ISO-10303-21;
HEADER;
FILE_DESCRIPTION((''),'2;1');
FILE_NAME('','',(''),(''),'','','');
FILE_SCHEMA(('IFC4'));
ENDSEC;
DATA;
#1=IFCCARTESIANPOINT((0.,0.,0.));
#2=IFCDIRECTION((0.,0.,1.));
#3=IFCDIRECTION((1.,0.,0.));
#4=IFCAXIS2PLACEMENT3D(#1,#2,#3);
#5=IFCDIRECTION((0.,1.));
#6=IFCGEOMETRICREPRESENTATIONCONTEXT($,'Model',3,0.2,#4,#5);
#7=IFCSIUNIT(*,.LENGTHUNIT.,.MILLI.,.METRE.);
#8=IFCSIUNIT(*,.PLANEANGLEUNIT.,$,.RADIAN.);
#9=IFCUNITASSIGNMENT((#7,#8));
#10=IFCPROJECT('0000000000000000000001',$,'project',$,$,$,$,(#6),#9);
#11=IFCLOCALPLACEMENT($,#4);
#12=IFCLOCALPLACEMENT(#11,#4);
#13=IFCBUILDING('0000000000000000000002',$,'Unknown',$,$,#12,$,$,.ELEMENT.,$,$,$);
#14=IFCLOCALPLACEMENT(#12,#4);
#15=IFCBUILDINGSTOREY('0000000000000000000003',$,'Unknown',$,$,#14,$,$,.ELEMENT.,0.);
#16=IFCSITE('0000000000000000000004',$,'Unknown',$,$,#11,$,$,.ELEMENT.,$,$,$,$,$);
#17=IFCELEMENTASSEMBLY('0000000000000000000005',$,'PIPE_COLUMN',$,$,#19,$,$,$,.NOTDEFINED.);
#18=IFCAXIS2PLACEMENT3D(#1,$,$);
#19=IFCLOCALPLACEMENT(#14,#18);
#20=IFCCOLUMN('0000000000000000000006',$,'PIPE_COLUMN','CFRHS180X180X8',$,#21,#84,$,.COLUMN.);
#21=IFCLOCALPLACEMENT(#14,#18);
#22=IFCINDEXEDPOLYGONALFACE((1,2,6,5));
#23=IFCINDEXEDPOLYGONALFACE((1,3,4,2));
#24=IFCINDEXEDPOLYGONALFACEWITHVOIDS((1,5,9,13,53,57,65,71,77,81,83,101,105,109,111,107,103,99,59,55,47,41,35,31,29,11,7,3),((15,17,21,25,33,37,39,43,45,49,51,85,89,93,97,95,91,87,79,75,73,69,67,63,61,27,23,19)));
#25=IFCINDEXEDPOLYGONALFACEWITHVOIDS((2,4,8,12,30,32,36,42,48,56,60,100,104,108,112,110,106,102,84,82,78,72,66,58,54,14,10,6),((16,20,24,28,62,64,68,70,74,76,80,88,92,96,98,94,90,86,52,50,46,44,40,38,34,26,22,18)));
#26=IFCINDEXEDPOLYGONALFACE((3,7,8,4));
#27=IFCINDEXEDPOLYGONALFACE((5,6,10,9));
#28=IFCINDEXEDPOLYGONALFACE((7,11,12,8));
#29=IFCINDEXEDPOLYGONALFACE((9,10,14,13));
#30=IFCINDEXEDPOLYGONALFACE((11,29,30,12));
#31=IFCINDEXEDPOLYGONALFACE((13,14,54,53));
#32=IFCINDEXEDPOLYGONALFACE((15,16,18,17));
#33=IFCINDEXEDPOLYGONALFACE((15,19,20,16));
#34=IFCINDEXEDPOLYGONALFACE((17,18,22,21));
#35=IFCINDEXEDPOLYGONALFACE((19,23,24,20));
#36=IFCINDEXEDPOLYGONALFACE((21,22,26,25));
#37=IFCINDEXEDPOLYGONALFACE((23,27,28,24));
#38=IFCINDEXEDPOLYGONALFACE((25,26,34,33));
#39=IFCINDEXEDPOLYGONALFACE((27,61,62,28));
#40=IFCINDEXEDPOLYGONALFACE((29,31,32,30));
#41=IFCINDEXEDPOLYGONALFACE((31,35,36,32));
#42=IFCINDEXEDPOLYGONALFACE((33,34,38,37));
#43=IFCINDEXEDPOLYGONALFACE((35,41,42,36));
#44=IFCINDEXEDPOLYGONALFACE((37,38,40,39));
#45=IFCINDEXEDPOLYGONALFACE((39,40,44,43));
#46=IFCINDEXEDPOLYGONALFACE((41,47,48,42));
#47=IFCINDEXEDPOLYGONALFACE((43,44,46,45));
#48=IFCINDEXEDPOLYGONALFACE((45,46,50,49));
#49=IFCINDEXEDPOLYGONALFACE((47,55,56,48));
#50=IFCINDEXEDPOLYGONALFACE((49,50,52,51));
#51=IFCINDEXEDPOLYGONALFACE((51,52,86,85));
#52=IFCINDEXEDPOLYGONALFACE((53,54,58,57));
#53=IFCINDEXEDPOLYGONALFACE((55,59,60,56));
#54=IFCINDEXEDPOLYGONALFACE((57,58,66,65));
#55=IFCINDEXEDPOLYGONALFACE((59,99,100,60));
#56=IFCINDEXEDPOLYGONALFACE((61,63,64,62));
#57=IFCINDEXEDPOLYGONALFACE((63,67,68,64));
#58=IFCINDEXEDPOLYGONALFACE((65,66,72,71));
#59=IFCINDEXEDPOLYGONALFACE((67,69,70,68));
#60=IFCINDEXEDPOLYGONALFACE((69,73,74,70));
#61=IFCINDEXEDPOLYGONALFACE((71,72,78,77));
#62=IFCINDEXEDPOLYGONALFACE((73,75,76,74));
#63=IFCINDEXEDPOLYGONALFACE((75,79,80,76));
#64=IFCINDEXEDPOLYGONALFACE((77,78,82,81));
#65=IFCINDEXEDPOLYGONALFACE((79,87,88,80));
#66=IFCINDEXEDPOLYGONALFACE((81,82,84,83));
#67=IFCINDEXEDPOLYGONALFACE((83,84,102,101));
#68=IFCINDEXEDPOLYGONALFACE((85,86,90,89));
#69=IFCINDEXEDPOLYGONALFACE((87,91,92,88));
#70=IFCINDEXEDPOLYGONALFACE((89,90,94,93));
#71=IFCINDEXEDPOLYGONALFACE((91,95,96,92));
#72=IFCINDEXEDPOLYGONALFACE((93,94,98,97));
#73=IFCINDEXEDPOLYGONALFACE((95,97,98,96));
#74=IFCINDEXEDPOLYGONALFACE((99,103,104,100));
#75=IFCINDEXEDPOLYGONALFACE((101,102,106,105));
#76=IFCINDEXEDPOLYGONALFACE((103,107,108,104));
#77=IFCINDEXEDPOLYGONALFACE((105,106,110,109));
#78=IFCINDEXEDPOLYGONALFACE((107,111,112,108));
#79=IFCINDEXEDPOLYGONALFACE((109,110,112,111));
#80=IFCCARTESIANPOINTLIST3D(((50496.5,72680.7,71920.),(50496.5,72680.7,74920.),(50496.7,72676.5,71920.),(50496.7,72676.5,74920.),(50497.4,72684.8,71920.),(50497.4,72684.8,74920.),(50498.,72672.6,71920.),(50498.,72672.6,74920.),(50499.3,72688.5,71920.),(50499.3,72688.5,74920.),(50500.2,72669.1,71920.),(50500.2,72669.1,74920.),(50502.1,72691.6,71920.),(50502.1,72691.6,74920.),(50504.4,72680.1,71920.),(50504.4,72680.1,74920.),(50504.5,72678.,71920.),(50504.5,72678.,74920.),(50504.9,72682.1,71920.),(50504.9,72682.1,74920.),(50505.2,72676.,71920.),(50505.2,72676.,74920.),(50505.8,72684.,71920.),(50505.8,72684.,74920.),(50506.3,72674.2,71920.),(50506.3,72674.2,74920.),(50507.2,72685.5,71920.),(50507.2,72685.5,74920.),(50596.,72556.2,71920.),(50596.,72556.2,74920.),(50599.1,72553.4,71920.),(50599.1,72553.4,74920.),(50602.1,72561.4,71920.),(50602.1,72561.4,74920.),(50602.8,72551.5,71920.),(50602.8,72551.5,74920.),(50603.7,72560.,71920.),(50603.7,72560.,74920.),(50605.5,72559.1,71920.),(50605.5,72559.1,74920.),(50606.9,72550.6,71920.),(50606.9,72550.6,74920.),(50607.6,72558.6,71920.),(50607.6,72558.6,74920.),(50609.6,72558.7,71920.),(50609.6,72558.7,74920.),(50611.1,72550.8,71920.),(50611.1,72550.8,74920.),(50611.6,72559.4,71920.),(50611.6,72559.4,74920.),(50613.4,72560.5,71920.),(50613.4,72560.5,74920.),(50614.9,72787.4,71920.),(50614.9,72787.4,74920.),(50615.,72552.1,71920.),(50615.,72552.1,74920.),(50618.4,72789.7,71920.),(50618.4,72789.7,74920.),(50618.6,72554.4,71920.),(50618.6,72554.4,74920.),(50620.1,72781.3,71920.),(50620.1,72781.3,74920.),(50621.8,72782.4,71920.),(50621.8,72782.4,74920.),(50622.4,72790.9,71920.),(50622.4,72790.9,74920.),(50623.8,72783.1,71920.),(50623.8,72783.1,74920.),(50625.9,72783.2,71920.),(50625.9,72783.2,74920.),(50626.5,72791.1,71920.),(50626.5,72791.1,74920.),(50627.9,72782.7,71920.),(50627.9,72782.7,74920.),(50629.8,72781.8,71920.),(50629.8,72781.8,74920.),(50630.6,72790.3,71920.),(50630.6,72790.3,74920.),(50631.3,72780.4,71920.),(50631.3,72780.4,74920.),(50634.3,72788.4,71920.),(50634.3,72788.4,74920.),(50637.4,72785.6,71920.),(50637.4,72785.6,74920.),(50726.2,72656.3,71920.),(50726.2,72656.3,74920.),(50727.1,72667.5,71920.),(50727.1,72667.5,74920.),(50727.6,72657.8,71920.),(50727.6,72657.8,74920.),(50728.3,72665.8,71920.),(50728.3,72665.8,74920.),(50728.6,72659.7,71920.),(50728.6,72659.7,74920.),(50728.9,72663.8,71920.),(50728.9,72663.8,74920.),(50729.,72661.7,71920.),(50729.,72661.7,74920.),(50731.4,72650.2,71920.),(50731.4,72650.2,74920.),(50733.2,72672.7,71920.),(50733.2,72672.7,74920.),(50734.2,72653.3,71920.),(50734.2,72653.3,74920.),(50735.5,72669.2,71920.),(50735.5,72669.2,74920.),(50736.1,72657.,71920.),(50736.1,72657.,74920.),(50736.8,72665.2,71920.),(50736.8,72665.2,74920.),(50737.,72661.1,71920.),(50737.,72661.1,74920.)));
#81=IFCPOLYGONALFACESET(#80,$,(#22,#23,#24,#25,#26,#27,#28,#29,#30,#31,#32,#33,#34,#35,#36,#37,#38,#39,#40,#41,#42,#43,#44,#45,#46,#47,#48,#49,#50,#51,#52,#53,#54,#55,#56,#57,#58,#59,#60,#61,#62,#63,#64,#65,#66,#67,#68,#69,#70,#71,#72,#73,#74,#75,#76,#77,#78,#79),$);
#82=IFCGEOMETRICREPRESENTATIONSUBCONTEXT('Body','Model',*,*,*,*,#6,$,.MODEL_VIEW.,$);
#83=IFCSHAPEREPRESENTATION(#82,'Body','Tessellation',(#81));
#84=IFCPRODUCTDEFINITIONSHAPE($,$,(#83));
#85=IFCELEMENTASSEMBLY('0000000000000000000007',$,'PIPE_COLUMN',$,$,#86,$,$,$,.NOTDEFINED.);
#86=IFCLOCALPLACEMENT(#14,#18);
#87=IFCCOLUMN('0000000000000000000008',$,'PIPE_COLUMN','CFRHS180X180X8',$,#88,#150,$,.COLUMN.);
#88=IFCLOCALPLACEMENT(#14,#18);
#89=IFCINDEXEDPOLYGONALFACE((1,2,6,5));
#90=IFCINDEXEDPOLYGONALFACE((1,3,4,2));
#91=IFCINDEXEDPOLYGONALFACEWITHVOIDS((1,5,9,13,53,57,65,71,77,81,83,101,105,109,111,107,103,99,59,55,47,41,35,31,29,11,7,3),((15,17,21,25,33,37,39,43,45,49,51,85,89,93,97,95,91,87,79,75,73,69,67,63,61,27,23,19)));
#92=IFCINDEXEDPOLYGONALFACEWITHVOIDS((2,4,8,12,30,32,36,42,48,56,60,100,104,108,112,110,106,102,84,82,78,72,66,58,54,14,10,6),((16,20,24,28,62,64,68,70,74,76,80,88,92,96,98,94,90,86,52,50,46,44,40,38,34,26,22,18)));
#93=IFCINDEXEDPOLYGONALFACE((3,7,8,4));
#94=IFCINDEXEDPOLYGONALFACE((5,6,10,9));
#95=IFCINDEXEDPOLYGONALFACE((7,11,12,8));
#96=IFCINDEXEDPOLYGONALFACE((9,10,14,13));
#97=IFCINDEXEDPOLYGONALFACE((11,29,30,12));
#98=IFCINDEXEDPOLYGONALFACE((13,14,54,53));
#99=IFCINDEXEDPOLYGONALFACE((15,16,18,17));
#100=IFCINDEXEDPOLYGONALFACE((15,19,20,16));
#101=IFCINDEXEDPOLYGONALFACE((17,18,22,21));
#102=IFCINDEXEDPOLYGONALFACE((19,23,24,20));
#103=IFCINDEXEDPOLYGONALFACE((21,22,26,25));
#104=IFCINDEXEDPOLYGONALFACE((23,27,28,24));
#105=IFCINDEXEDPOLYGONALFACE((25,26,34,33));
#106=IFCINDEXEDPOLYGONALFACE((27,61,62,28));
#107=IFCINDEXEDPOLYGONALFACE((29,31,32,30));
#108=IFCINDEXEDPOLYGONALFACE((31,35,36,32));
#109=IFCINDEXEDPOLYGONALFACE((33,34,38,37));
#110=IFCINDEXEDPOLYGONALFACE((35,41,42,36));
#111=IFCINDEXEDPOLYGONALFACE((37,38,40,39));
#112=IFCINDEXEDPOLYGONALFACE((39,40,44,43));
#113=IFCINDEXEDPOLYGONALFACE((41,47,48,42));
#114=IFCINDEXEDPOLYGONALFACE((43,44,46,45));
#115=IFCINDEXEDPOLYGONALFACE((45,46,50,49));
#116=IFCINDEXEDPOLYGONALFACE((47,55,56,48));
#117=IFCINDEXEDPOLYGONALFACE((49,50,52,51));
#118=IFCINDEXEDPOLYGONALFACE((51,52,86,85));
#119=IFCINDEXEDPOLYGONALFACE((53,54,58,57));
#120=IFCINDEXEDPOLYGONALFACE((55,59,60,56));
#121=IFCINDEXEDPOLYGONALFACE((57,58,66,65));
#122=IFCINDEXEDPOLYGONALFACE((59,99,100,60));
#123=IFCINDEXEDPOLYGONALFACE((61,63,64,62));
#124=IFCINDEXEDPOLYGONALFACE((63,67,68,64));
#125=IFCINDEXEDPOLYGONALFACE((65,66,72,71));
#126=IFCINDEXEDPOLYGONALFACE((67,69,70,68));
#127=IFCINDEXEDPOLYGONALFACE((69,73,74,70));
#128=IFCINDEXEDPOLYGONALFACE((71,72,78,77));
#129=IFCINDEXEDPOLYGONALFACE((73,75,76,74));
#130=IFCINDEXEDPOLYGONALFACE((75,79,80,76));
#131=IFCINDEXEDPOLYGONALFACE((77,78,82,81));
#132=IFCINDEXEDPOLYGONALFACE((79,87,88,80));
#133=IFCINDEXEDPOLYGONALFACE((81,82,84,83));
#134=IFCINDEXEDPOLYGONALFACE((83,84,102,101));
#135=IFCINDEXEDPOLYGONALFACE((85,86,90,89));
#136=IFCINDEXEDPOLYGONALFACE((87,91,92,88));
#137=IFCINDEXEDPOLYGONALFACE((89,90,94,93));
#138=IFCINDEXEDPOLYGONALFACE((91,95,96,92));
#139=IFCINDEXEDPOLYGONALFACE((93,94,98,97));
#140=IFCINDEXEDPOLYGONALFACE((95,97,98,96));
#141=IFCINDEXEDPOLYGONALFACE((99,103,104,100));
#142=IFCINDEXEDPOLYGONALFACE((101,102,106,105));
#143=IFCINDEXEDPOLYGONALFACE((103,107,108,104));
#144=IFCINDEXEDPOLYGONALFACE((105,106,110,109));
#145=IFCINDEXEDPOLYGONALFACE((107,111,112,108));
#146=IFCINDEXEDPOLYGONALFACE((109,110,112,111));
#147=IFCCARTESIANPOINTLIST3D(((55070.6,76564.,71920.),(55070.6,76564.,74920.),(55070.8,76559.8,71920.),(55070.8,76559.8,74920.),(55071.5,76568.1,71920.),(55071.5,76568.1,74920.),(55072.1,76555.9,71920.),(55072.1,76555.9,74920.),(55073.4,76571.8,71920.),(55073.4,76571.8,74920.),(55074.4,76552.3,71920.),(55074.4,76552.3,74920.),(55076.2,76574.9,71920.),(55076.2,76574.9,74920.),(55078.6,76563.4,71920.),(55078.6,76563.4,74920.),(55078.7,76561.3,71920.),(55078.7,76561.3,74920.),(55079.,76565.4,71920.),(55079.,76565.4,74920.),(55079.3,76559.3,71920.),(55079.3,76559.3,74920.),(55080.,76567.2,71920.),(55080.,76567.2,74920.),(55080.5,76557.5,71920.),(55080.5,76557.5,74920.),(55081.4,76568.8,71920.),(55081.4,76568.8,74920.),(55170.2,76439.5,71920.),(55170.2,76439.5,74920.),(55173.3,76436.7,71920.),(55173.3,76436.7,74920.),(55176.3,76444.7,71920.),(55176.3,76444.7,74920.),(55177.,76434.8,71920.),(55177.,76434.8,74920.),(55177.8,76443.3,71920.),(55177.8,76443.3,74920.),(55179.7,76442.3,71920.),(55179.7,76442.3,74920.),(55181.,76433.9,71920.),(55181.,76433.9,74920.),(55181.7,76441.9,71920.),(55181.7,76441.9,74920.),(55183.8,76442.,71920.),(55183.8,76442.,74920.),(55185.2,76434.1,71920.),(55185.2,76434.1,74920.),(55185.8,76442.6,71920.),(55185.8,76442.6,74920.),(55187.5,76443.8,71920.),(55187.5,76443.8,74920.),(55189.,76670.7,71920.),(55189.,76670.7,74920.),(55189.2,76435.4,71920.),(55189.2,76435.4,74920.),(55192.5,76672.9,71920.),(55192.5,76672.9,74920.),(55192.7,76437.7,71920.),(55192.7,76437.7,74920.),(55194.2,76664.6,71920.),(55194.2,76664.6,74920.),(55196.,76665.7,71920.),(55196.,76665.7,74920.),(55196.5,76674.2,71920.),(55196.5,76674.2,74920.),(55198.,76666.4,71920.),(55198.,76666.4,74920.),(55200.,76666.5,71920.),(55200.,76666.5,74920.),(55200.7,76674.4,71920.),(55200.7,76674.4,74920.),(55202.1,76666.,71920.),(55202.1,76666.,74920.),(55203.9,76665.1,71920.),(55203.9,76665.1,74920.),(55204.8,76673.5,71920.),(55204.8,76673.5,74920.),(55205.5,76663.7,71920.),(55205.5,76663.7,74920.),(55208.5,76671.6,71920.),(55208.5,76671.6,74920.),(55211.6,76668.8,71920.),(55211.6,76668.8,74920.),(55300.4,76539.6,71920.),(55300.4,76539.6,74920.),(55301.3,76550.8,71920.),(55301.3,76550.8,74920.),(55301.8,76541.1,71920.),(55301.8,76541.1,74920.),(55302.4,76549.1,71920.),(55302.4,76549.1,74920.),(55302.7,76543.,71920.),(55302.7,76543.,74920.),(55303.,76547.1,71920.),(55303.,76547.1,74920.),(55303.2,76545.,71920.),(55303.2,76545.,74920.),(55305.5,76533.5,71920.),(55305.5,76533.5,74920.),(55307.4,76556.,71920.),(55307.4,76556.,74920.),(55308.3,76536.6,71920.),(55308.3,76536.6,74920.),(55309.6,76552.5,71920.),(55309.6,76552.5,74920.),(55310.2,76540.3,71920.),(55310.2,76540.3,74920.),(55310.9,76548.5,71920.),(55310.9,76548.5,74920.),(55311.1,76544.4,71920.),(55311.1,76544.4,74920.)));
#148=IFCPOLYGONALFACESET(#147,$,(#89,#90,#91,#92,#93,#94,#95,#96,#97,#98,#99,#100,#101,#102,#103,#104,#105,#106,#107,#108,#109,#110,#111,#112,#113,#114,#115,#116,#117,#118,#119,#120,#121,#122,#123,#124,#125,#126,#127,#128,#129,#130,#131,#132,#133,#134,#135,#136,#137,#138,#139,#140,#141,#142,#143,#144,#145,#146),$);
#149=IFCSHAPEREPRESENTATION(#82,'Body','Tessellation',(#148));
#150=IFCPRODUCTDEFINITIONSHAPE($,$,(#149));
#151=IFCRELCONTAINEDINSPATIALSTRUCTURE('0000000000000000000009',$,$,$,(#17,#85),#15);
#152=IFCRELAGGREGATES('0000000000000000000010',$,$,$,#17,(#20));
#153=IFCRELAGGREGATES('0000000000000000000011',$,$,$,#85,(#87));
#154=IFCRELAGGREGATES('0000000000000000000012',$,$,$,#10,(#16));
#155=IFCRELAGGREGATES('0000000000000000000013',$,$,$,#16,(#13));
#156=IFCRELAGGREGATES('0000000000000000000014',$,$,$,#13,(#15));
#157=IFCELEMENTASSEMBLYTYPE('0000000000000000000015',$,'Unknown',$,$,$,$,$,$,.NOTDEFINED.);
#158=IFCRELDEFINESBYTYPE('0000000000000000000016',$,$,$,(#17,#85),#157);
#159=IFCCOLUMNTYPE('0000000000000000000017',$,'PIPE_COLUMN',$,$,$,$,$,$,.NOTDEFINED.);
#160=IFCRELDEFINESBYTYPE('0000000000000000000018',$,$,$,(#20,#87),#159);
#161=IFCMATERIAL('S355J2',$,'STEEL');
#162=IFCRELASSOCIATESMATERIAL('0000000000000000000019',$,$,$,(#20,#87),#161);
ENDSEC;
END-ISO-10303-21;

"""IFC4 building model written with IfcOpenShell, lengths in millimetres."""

from ifc_helpers import new_model, si_unit, direction, frame, origin_with_axes, origin_2d_with_axis, place, context, subcontext, project, spatial, hollow_rectangle, extrude, material, material_profile, profile_set, profile_usage, type_object, element, aggregate, save


model = new_model("IFC4")

# Units and contexts
model_context = context("Model", 3, precision=0.2, world=origin_with_axes(), true_north=direction((0.0, 1.0)))
body_context = subcontext(model_context, "Body", "Model", "MODEL_VIEW")
ifc_project = project(units=[si_unit("LENGTHUNIT", "METRE", prefix="MILLI"), si_unit("PLANEANGLEUNIT", "RADIAN")], contexts=[model_context])

# Site, building, storey
site_placement = place(None, origin_with_axes())
site = spatial("IfcSite", under=ifc_project, at=site_placement, Name="Unknown", CompositionType="ELEMENT")
building_placement = place(site_placement, origin_with_axes())
building = spatial("IfcBuilding", under=site, at=building_placement, Name="Unknown", CompositionType="ELEMENT")
storey_placement = place(building_placement, origin_with_axes())
storey = spatial("IfcBuildingStorey", under=building, at=storey_placement, Name="Unknown", CompositionType="ELEMENT", Elevation=0.0)

# Element assemblies, columns
element_assembly_type = type_object("IfcElementAssemblyType", Name="Unknown", PredefinedType="NOTDEFINED")
ifc_material_1 = material(Name="S355J2", Category="STEEL")
ifc_material_profile_1 = material_profile(ifc_material_1, hollow_rectangle(XDim=180.0, YDim=180.0, WallThickness=8.0, InnerFilletRadius=8.0, OuterFilletRadius=16.0, at=origin_2d_with_axis()), Name="CFRHS180X180X8")
ifc_profile_set_1 = profile_set([ifc_material_profile_1])
ifc_profile_usage_1 = profile_usage(ifc_profile_set_1, cardinal=9)
column_type_1 = type_object("IfcColumnType", Name="PIPE_COLUMN")
assembly_1_placement = place(storey_placement, frame((50616.7, 72670.9, 71920.0), z_axis=(-0.762329, -0.64719, 0.0), x_axis=(0.0, 0.0, 1.0)))
assembly_1 = element("IfcElementAssembly", 1, at=assembly_1_placement, inside=storey, type_object=element_assembly_type, Name="PIPE_COLUMN", PredefinedType="NOTDEFINED")
column_1_placement = place(assembly_1_placement, origin_with_axes())
column_1 = element("IfcColumn", 2, at=column_1_placement, type_object=column_type_1, material=ifc_profile_usage_1, Name="PIPE_COLUMN", Description="CFRHS180X180X8", PredefinedType="COLUMN", context=body_context, shape_type="SolidModel", body=[
    extrude(hollow_rectangle(XDim=180.0, YDim=180.0, WallThickness=8.0, InnerFilletRadius=8.0, OuterFilletRadius=16.0, at=origin_2d_with_axis()), frame((0.0, 0.0, 0.0), z_axis=(-1.0, 0.0, 0.0), x_axis=(0.0, 0.0, 1.0)), (0.0, 0.0, -1.0), 3000.0),
])
aggregate(assembly_1, [column_1])
assembly_2_placement = place(storey_placement, frame((55190.9, 76554.2, 71920.0), z_axis=(-0.762329, -0.64719, 0.0), x_axis=(0.0, 0.0, 1.0)))
assembly_2 = element("IfcElementAssembly", 3, at=assembly_2_placement, inside=storey, type_object=element_assembly_type, Name="PIPE_COLUMN", PredefinedType="NOTDEFINED")
column_2_placement = place(assembly_2_placement, origin_with_axes())
column_2 = element("IfcColumn", 4, at=column_2_placement, type_object=column_type_1, material=ifc_profile_usage_1, Name="PIPE_COLUMN", Description="CFRHS180X180X8", PredefinedType="COLUMN", context=body_context, shape_type="SolidModel", body=[
    extrude(hollow_rectangle(XDim=180.0, YDim=180.0, WallThickness=8.0, InnerFilletRadius=8.0, OuterFilletRadius=16.0, at=origin_2d_with_axis()), frame((0.0, 0.0, 0.0), z_axis=(-1.0, 0.0, 0.0), x_axis=(0.0, 0.0, 1.0)), (0.0, 0.0, -1.0), 3000.0),
])
aggregate(assembly_2, [column_2])

save(model, "model.ifc")
